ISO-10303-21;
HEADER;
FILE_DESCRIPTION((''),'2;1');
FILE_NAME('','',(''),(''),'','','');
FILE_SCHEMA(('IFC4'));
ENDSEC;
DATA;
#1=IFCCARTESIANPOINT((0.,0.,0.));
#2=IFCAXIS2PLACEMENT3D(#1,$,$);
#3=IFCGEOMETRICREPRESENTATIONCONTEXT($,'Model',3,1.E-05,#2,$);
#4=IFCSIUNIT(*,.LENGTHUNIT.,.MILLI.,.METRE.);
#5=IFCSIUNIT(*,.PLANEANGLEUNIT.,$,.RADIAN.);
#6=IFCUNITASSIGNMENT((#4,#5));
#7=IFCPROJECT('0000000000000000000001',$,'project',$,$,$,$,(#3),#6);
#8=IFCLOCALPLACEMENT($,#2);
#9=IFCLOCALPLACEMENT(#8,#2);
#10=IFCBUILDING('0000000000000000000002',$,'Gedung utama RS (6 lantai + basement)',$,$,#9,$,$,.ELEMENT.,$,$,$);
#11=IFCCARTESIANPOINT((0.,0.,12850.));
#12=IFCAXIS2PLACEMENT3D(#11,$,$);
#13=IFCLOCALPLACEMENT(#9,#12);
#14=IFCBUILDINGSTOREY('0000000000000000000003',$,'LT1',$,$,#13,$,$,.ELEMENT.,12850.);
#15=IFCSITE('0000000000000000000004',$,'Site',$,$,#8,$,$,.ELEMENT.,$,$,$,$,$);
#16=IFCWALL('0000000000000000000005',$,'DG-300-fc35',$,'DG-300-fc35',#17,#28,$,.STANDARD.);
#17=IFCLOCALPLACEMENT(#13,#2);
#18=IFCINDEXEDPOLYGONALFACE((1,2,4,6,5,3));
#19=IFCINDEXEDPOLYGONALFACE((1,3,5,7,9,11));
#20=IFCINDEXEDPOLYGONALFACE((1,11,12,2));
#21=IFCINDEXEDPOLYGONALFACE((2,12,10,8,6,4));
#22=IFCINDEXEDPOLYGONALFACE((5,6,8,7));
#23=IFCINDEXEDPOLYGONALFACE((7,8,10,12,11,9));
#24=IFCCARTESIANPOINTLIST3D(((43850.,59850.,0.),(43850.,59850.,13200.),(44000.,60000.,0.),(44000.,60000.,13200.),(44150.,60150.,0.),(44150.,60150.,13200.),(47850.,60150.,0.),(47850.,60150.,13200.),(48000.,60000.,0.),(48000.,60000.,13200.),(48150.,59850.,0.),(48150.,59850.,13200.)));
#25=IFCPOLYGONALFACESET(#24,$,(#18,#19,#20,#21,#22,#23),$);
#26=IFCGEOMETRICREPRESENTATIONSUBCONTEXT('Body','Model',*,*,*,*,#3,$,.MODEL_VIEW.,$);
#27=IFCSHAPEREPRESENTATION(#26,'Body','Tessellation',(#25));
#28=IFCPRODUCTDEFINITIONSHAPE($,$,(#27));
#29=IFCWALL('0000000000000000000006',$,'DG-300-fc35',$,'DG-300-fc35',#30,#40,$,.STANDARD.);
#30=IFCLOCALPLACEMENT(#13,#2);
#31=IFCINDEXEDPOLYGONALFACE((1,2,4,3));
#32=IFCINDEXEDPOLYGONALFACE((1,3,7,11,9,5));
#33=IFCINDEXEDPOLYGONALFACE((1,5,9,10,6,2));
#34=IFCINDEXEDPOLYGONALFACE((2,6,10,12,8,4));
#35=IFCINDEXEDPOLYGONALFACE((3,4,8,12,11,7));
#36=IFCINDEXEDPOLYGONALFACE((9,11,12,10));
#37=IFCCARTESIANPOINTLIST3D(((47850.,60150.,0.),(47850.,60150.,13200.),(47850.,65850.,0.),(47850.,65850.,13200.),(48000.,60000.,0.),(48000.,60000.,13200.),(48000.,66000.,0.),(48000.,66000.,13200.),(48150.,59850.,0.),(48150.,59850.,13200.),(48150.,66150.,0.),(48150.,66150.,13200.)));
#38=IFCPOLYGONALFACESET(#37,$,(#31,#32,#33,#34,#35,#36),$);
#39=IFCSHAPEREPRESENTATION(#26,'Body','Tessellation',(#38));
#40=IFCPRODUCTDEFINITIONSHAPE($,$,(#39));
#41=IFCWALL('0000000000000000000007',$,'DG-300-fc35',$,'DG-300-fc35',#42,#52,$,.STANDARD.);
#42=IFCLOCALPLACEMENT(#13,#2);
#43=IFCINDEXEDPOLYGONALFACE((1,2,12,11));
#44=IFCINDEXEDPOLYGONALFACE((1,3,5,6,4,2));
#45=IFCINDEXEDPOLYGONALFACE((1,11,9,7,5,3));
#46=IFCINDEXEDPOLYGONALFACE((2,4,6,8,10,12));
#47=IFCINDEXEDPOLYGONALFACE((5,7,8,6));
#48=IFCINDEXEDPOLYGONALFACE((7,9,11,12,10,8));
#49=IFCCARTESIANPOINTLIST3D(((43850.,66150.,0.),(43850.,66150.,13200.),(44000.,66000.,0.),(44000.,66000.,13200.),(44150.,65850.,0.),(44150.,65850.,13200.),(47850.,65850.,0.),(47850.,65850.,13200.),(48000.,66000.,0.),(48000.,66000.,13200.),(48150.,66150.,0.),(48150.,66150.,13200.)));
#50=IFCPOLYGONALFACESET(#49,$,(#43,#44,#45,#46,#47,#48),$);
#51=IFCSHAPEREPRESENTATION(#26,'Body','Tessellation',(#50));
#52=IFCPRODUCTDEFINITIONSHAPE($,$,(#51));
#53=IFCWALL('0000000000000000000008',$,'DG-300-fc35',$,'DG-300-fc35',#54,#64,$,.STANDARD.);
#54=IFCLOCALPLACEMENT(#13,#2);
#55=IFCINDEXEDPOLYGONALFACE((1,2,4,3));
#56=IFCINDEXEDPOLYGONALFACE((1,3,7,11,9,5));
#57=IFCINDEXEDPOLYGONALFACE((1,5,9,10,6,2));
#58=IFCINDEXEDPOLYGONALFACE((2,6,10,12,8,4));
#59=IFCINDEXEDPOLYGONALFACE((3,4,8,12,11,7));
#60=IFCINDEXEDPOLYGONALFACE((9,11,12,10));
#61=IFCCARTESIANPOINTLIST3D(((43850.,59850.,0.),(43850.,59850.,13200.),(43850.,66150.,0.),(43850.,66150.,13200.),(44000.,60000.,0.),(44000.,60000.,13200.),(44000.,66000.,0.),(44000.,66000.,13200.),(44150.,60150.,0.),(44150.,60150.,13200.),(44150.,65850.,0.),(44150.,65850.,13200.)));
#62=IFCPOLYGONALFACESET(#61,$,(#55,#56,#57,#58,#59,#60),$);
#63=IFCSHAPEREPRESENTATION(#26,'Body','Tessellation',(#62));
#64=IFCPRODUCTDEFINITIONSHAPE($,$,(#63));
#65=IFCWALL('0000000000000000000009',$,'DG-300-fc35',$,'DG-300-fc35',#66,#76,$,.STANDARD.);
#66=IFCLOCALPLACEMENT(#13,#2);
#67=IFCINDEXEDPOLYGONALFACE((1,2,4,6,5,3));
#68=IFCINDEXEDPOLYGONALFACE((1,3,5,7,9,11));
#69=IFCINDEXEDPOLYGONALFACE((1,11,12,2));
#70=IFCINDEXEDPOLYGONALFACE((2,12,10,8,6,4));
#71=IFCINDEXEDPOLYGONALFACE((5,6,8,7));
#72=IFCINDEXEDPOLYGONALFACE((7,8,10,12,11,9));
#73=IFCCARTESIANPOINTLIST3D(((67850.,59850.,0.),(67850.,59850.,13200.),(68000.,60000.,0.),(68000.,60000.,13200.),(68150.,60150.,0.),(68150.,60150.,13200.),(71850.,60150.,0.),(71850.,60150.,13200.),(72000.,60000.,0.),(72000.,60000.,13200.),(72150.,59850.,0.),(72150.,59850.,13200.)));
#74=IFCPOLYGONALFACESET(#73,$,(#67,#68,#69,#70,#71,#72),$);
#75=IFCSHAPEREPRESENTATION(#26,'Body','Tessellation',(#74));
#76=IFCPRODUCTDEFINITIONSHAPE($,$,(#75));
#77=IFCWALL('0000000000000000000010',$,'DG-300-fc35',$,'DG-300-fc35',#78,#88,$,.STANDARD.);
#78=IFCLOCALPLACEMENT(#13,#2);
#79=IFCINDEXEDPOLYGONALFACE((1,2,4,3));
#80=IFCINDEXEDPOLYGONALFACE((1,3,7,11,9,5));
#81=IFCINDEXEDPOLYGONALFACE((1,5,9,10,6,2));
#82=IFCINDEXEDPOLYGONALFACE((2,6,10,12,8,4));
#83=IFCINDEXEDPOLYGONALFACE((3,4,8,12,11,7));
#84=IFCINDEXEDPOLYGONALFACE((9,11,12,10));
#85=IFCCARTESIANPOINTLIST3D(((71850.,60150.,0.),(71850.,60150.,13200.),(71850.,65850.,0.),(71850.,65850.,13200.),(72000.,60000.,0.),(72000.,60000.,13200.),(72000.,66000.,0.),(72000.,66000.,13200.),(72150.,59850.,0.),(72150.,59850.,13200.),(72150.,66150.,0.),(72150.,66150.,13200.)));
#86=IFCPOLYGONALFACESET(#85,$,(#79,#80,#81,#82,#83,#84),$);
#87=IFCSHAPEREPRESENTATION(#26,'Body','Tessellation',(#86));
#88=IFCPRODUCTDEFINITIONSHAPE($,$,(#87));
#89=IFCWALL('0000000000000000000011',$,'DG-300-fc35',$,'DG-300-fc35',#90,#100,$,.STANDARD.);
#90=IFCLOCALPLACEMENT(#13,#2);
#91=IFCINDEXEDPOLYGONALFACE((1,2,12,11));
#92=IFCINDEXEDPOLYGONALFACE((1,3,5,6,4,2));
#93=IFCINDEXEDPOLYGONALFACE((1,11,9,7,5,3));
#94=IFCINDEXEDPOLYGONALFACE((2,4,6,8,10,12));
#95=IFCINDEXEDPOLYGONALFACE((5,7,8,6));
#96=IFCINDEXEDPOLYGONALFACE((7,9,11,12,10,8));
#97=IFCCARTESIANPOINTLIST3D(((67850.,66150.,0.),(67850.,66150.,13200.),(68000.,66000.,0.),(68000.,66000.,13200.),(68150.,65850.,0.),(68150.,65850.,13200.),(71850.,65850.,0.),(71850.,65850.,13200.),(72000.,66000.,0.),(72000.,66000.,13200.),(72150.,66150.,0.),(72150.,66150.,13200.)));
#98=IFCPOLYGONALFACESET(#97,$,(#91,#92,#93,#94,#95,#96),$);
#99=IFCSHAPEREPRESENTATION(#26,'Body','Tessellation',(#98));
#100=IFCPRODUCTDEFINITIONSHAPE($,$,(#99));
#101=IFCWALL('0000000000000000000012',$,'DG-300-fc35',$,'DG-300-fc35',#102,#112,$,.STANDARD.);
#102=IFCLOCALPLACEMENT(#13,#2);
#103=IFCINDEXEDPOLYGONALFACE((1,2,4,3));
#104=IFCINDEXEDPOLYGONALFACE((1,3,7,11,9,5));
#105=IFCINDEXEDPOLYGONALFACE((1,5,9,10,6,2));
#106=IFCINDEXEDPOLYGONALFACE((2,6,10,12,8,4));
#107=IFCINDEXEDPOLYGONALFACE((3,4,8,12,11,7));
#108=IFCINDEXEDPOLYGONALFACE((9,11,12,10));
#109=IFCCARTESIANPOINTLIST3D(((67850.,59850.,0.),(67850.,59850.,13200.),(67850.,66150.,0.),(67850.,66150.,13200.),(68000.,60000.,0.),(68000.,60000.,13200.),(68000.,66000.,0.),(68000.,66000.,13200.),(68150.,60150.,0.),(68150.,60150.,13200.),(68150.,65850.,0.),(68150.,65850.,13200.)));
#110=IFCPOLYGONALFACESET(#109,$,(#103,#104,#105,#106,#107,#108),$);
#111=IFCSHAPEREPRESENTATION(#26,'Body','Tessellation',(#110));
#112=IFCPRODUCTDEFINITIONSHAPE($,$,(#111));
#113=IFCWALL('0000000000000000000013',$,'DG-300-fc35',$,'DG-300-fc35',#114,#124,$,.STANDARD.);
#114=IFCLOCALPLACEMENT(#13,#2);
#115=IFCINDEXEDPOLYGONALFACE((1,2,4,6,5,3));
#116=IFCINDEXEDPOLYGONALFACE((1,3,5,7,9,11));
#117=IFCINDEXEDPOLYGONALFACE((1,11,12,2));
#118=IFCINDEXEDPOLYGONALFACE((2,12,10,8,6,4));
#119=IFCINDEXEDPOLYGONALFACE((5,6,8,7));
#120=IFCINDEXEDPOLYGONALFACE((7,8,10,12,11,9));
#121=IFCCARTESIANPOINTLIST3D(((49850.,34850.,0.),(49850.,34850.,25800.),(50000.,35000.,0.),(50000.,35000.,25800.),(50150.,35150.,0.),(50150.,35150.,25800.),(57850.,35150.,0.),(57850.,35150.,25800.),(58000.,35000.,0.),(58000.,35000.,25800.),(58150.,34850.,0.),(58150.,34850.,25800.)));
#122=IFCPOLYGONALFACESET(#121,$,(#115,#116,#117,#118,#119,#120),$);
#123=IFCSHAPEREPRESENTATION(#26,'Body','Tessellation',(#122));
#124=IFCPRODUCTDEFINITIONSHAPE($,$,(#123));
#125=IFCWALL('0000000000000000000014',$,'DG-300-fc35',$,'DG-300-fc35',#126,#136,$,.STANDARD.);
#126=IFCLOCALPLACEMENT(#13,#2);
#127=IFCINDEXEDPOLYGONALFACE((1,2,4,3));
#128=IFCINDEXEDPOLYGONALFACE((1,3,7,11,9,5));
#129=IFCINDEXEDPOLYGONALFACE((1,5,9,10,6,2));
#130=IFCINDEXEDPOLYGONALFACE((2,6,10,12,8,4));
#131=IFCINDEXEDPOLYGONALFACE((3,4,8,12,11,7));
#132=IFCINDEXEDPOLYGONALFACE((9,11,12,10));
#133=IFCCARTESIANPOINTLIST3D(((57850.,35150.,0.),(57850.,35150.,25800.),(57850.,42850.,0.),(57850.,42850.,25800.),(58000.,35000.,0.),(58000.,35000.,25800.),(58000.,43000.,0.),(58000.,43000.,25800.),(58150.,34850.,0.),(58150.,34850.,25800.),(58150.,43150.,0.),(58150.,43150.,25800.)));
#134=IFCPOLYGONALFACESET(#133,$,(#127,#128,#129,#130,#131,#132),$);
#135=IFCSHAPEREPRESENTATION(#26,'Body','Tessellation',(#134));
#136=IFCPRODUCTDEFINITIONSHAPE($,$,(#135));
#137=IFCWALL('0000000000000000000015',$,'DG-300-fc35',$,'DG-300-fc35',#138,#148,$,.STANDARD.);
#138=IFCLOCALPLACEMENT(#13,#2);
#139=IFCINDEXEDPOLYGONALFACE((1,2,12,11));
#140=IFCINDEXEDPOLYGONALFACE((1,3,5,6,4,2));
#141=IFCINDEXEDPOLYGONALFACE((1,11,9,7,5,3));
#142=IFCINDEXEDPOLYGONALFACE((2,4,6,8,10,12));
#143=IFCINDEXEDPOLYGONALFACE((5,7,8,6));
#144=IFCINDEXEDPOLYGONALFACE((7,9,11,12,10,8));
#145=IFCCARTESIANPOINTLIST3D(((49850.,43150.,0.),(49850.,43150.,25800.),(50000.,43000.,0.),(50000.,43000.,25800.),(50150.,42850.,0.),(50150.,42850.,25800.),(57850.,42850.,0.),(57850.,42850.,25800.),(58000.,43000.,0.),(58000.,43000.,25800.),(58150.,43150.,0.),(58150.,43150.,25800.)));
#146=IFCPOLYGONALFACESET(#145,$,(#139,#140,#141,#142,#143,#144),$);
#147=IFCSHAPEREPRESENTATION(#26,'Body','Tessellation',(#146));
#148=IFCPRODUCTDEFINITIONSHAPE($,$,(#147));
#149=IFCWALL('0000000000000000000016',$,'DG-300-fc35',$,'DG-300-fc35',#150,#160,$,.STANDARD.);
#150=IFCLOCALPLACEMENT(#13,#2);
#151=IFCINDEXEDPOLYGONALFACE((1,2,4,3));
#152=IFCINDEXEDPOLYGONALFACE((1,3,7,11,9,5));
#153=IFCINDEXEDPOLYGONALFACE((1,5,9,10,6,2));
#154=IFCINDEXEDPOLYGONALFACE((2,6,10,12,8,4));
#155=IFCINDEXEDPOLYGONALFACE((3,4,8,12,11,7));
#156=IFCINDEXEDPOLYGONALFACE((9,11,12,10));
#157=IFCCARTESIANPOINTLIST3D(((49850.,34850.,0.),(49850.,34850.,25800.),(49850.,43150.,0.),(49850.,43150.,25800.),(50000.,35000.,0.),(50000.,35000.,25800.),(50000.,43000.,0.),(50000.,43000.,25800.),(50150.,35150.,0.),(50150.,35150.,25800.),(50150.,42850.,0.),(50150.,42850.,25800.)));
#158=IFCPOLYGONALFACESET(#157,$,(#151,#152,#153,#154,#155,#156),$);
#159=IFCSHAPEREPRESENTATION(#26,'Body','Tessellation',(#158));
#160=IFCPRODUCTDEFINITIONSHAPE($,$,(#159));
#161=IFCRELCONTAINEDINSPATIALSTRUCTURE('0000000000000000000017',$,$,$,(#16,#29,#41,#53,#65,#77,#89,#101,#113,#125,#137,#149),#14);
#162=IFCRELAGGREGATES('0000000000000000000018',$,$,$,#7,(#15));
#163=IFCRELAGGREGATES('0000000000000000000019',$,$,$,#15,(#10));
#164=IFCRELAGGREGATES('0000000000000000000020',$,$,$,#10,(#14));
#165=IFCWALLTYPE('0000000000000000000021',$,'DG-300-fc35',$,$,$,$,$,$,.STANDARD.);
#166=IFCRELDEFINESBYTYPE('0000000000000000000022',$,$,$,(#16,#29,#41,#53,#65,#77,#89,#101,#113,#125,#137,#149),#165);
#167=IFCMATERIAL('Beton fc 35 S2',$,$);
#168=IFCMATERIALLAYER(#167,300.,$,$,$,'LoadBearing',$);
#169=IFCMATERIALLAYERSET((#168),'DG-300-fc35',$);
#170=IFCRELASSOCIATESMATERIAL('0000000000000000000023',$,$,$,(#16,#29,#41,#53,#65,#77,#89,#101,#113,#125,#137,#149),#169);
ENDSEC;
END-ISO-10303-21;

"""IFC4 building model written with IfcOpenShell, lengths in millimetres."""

from ifc_helpers import new_model, si_unit, frame, origin, place, context, subcontext, project, spatial, polyline, outline, extrude, material, layer, layer_set, layer_usage, type_object, element, save


model = new_model("IFC4")

# Units and contexts
model_context = context("Model", 3, precision=1e-05, world=origin())
body_context = subcontext(model_context, "Body", "Model", "MODEL_VIEW")
ifc_project = project(units=[si_unit("LENGTHUNIT", "METRE", prefix="MILLI"), si_unit("PLANEANGLEUNIT", "RADIAN")], contexts=[model_context])

# Site, building, storey
site_placement = place(None, origin())
site = spatial("IfcSite", under=ifc_project, at=site_placement, Name="Site", CompositionType="ELEMENT")
building_placement = place(site_placement, origin())
building = spatial("IfcBuilding", under=site, at=building_placement, Name="Gedung utama RS (6 lantai + basement)", CompositionType="ELEMENT")
storey_placement = place(building_placement, frame((0.0, 0.0, 12850.0)))
storey = spatial("IfcBuildingStorey", under=building, at=storey_placement, Name="LT1", CompositionType="ELEMENT", Elevation=12850.0)

# Walls
ifc_material_1 = material(Name="Beton fc 35 S2")
ifc_layer_1 = layer(ifc_material_1, 300.0, Category="LoadBearing")
ifc_layer_set_1 = layer_set([ifc_layer_1], Name="DG-300-fc35")
ifc_layer_usage_1 = layer_usage(ifc_layer_set_1, "AXIS2", "NEGATIVE", 150.0)
wall_type_1 = type_object("IfcWallType", Name="DG-300-fc35", PredefinedType="STANDARD")
wall_1_placement = place(storey_placement, frame((44000.0, 60000.0, 0.0), z_axis=(0.0, 0.0, 1.0), x_axis=(1.0, 0.0, 0.0)))
element("IfcWall", 1, at=wall_1_placement, inside=storey, type_object=wall_type_1, material=ifc_layer_usage_1, Name="DG-300-fc35", ObjectType="DG-300-fc35", PredefinedType="STANDARD", context=body_context, shape_type="SweptSolid", body=[
    extrude(outline(polyline([(-150.0, -150.0), (0.0, 0.0), (150.0, 150.0), (3850.0, 150.0), (4000.0, 0.0), (4150.0, -150.0), (-150.0, -150.0)])), origin(), (0.0, 0.0, 1.0), 13200.0),
])
wall_2_placement = place(storey_placement, frame((48000.0, 60000.0, 0.0), z_axis=(0.0, 0.0, 1.0), x_axis=(0.0, 1.0, 0.0)))
element("IfcWall", 2, at=wall_2_placement, inside=storey, type_object=wall_type_1, material=ifc_layer_usage_1, Name="DG-300-fc35", ObjectType="DG-300-fc35", PredefinedType="STANDARD", context=body_context, shape_type="SweptSolid", body=[
    extrude(outline(polyline([(-150.0, -150.0), (0.0, 0.0), (150.0, 150.0), (5850.0, 150.0), (6000.0, 0.0), (6150.0, -150.0), (-150.0, -150.0)])), origin(), (0.0, 0.0, 1.0), 13200.0),
])
wall_3_placement = place(storey_placement, frame((48000.0, 66000.0, 0.0), z_axis=(0.0, 0.0, 1.0), x_axis=(-1.0, 0.0, 0.0)))
element("IfcWall", 3, at=wall_3_placement, inside=storey, type_object=wall_type_1, material=ifc_layer_usage_1, Name="DG-300-fc35", ObjectType="DG-300-fc35", PredefinedType="STANDARD", context=body_context, shape_type="SweptSolid", body=[
    extrude(outline(polyline([(-150.0, -150.0), (0.0, 0.0), (150.0, 150.0), (3850.0, 150.0), (4000.0, 0.0), (4150.0, -150.0), (-150.0, -150.0)])), origin(), (0.0, 0.0, 1.0), 13200.0),
])
wall_4_placement = place(storey_placement, frame((44000.0, 66000.0, 0.0), z_axis=(0.0, 0.0, 1.0), x_axis=(0.0, -1.0, 0.0)))
element("IfcWall", 4, at=wall_4_placement, inside=storey, type_object=wall_type_1, material=ifc_layer_usage_1, Name="DG-300-fc35", ObjectType="DG-300-fc35", PredefinedType="STANDARD", context=body_context, shape_type="SweptSolid", body=[
    extrude(outline(polyline([(-150.0, -150.0), (0.0, 0.0), (150.0, 150.0), (5850.0, 150.0), (6000.0, 0.0), (6150.0, -150.0), (-150.0, -150.0)])), origin(), (0.0, 0.0, 1.0), 13200.0),
])
wall_5_placement = place(storey_placement, frame((68000.0, 60000.0, 0.0), z_axis=(0.0, 0.0, 1.0), x_axis=(1.0, 0.0, 0.0)))
element("IfcWall", 5, at=wall_5_placement, inside=storey, type_object=wall_type_1, material=ifc_layer_usage_1, Name="DG-300-fc35", ObjectType="DG-300-fc35", PredefinedType="STANDARD", context=body_context, shape_type="SweptSolid", body=[
    extrude(outline(polyline([(-150.0, -150.0), (0.0, 0.0), (150.0, 150.0), (3850.0, 150.0), (4000.0, 0.0), (4150.0, -150.0), (-150.0, -150.0)])), origin(), (0.0, 0.0, 1.0), 13200.0),
])
wall_6_placement = place(storey_placement, frame((72000.0, 60000.0, 0.0), z_axis=(0.0, 0.0, 1.0), x_axis=(0.0, 1.0, 0.0)))
element("IfcWall", 6, at=wall_6_placement, inside=storey, type_object=wall_type_1, material=ifc_layer_usage_1, Name="DG-300-fc35", ObjectType="DG-300-fc35", PredefinedType="STANDARD", context=body_context, shape_type="SweptSolid", body=[
    extrude(outline(polyline([(-150.0, -150.0), (0.0, 0.0), (150.0, 150.0), (5850.0, 150.0), (6000.0, 0.0), (6150.0, -150.0), (-150.0, -150.0)])), origin(), (0.0, 0.0, 1.0), 13200.0),
])
wall_7_placement = place(storey_placement, frame((72000.0, 66000.0, 0.0), z_axis=(0.0, 0.0, 1.0), x_axis=(-1.0, 0.0, 0.0)))
element("IfcWall", 7, at=wall_7_placement, inside=storey, type_object=wall_type_1, material=ifc_layer_usage_1, Name="DG-300-fc35", ObjectType="DG-300-fc35", PredefinedType="STANDARD", context=body_context, shape_type="SweptSolid", body=[
    extrude(outline(polyline([(-150.0, -150.0), (0.0, 0.0), (150.0, 150.0), (3850.0, 150.0), (4000.0, 0.0), (4150.0, -150.0), (-150.0, -150.0)])), origin(), (0.0, 0.0, 1.0), 13200.0),
])
wall_8_placement = place(storey_placement, frame((68000.0, 66000.0, 0.0), z_axis=(0.0, 0.0, 1.0), x_axis=(0.0, -1.0, 0.0)))
element("IfcWall", 8, at=wall_8_placement, inside=storey, type_object=wall_type_1, material=ifc_layer_usage_1, Name="DG-300-fc35", ObjectType="DG-300-fc35", PredefinedType="STANDARD", context=body_context, shape_type="SweptSolid", body=[
    extrude(outline(polyline([(-150.0, -150.0), (0.0, 0.0), (150.0, 150.0), (5850.0, 150.0), (6000.0, 0.0), (6150.0, -150.0), (-150.0, -150.0)])), origin(), (0.0, 0.0, 1.0), 13200.0),
])
for number, where, z_axis, x_axis, name in (
    (9, (50000.0, 35000.0, 0.0), (0.0, 0.0, 1.0), (1.0, 0.0, 0.0), "DG-300-fc35"),
    (10, (58000.0, 35000.0, 0.0), (0.0, 0.0, 1.0), (0.0, 1.0, 0.0), "DG-300-fc35"),
    (11, (58000.0, 43000.0, 0.0), (0.0, 0.0, 1.0), (-1.0, 0.0, 0.0), "DG-300-fc35"),
    (12, (50000.0, 43000.0, 0.0), (0.0, 0.0, 1.0), (0.0, -1.0, 0.0), "DG-300-fc35"),
):
    element("IfcWall", number, at=place(storey_placement, frame(where, z_axis=z_axis, x_axis=x_axis)), inside=storey, type_object=wall_type_1, material=ifc_layer_usage_1, Name=name, ObjectType="DG-300-fc35", PredefinedType="STANDARD", context=body_context, shape_type="SweptSolid", body=[
        extrude(outline(polyline([(-150.0, -150.0), (0.0, 0.0), (150.0, 150.0), (7850.0, 150.0), (8000.0, 0.0), (8150.0, -150.0), (-150.0, -150.0)])), origin(), (0.0, 0.0, 1.0), 25800.0),
    ])

save(model, "model.ifc")
